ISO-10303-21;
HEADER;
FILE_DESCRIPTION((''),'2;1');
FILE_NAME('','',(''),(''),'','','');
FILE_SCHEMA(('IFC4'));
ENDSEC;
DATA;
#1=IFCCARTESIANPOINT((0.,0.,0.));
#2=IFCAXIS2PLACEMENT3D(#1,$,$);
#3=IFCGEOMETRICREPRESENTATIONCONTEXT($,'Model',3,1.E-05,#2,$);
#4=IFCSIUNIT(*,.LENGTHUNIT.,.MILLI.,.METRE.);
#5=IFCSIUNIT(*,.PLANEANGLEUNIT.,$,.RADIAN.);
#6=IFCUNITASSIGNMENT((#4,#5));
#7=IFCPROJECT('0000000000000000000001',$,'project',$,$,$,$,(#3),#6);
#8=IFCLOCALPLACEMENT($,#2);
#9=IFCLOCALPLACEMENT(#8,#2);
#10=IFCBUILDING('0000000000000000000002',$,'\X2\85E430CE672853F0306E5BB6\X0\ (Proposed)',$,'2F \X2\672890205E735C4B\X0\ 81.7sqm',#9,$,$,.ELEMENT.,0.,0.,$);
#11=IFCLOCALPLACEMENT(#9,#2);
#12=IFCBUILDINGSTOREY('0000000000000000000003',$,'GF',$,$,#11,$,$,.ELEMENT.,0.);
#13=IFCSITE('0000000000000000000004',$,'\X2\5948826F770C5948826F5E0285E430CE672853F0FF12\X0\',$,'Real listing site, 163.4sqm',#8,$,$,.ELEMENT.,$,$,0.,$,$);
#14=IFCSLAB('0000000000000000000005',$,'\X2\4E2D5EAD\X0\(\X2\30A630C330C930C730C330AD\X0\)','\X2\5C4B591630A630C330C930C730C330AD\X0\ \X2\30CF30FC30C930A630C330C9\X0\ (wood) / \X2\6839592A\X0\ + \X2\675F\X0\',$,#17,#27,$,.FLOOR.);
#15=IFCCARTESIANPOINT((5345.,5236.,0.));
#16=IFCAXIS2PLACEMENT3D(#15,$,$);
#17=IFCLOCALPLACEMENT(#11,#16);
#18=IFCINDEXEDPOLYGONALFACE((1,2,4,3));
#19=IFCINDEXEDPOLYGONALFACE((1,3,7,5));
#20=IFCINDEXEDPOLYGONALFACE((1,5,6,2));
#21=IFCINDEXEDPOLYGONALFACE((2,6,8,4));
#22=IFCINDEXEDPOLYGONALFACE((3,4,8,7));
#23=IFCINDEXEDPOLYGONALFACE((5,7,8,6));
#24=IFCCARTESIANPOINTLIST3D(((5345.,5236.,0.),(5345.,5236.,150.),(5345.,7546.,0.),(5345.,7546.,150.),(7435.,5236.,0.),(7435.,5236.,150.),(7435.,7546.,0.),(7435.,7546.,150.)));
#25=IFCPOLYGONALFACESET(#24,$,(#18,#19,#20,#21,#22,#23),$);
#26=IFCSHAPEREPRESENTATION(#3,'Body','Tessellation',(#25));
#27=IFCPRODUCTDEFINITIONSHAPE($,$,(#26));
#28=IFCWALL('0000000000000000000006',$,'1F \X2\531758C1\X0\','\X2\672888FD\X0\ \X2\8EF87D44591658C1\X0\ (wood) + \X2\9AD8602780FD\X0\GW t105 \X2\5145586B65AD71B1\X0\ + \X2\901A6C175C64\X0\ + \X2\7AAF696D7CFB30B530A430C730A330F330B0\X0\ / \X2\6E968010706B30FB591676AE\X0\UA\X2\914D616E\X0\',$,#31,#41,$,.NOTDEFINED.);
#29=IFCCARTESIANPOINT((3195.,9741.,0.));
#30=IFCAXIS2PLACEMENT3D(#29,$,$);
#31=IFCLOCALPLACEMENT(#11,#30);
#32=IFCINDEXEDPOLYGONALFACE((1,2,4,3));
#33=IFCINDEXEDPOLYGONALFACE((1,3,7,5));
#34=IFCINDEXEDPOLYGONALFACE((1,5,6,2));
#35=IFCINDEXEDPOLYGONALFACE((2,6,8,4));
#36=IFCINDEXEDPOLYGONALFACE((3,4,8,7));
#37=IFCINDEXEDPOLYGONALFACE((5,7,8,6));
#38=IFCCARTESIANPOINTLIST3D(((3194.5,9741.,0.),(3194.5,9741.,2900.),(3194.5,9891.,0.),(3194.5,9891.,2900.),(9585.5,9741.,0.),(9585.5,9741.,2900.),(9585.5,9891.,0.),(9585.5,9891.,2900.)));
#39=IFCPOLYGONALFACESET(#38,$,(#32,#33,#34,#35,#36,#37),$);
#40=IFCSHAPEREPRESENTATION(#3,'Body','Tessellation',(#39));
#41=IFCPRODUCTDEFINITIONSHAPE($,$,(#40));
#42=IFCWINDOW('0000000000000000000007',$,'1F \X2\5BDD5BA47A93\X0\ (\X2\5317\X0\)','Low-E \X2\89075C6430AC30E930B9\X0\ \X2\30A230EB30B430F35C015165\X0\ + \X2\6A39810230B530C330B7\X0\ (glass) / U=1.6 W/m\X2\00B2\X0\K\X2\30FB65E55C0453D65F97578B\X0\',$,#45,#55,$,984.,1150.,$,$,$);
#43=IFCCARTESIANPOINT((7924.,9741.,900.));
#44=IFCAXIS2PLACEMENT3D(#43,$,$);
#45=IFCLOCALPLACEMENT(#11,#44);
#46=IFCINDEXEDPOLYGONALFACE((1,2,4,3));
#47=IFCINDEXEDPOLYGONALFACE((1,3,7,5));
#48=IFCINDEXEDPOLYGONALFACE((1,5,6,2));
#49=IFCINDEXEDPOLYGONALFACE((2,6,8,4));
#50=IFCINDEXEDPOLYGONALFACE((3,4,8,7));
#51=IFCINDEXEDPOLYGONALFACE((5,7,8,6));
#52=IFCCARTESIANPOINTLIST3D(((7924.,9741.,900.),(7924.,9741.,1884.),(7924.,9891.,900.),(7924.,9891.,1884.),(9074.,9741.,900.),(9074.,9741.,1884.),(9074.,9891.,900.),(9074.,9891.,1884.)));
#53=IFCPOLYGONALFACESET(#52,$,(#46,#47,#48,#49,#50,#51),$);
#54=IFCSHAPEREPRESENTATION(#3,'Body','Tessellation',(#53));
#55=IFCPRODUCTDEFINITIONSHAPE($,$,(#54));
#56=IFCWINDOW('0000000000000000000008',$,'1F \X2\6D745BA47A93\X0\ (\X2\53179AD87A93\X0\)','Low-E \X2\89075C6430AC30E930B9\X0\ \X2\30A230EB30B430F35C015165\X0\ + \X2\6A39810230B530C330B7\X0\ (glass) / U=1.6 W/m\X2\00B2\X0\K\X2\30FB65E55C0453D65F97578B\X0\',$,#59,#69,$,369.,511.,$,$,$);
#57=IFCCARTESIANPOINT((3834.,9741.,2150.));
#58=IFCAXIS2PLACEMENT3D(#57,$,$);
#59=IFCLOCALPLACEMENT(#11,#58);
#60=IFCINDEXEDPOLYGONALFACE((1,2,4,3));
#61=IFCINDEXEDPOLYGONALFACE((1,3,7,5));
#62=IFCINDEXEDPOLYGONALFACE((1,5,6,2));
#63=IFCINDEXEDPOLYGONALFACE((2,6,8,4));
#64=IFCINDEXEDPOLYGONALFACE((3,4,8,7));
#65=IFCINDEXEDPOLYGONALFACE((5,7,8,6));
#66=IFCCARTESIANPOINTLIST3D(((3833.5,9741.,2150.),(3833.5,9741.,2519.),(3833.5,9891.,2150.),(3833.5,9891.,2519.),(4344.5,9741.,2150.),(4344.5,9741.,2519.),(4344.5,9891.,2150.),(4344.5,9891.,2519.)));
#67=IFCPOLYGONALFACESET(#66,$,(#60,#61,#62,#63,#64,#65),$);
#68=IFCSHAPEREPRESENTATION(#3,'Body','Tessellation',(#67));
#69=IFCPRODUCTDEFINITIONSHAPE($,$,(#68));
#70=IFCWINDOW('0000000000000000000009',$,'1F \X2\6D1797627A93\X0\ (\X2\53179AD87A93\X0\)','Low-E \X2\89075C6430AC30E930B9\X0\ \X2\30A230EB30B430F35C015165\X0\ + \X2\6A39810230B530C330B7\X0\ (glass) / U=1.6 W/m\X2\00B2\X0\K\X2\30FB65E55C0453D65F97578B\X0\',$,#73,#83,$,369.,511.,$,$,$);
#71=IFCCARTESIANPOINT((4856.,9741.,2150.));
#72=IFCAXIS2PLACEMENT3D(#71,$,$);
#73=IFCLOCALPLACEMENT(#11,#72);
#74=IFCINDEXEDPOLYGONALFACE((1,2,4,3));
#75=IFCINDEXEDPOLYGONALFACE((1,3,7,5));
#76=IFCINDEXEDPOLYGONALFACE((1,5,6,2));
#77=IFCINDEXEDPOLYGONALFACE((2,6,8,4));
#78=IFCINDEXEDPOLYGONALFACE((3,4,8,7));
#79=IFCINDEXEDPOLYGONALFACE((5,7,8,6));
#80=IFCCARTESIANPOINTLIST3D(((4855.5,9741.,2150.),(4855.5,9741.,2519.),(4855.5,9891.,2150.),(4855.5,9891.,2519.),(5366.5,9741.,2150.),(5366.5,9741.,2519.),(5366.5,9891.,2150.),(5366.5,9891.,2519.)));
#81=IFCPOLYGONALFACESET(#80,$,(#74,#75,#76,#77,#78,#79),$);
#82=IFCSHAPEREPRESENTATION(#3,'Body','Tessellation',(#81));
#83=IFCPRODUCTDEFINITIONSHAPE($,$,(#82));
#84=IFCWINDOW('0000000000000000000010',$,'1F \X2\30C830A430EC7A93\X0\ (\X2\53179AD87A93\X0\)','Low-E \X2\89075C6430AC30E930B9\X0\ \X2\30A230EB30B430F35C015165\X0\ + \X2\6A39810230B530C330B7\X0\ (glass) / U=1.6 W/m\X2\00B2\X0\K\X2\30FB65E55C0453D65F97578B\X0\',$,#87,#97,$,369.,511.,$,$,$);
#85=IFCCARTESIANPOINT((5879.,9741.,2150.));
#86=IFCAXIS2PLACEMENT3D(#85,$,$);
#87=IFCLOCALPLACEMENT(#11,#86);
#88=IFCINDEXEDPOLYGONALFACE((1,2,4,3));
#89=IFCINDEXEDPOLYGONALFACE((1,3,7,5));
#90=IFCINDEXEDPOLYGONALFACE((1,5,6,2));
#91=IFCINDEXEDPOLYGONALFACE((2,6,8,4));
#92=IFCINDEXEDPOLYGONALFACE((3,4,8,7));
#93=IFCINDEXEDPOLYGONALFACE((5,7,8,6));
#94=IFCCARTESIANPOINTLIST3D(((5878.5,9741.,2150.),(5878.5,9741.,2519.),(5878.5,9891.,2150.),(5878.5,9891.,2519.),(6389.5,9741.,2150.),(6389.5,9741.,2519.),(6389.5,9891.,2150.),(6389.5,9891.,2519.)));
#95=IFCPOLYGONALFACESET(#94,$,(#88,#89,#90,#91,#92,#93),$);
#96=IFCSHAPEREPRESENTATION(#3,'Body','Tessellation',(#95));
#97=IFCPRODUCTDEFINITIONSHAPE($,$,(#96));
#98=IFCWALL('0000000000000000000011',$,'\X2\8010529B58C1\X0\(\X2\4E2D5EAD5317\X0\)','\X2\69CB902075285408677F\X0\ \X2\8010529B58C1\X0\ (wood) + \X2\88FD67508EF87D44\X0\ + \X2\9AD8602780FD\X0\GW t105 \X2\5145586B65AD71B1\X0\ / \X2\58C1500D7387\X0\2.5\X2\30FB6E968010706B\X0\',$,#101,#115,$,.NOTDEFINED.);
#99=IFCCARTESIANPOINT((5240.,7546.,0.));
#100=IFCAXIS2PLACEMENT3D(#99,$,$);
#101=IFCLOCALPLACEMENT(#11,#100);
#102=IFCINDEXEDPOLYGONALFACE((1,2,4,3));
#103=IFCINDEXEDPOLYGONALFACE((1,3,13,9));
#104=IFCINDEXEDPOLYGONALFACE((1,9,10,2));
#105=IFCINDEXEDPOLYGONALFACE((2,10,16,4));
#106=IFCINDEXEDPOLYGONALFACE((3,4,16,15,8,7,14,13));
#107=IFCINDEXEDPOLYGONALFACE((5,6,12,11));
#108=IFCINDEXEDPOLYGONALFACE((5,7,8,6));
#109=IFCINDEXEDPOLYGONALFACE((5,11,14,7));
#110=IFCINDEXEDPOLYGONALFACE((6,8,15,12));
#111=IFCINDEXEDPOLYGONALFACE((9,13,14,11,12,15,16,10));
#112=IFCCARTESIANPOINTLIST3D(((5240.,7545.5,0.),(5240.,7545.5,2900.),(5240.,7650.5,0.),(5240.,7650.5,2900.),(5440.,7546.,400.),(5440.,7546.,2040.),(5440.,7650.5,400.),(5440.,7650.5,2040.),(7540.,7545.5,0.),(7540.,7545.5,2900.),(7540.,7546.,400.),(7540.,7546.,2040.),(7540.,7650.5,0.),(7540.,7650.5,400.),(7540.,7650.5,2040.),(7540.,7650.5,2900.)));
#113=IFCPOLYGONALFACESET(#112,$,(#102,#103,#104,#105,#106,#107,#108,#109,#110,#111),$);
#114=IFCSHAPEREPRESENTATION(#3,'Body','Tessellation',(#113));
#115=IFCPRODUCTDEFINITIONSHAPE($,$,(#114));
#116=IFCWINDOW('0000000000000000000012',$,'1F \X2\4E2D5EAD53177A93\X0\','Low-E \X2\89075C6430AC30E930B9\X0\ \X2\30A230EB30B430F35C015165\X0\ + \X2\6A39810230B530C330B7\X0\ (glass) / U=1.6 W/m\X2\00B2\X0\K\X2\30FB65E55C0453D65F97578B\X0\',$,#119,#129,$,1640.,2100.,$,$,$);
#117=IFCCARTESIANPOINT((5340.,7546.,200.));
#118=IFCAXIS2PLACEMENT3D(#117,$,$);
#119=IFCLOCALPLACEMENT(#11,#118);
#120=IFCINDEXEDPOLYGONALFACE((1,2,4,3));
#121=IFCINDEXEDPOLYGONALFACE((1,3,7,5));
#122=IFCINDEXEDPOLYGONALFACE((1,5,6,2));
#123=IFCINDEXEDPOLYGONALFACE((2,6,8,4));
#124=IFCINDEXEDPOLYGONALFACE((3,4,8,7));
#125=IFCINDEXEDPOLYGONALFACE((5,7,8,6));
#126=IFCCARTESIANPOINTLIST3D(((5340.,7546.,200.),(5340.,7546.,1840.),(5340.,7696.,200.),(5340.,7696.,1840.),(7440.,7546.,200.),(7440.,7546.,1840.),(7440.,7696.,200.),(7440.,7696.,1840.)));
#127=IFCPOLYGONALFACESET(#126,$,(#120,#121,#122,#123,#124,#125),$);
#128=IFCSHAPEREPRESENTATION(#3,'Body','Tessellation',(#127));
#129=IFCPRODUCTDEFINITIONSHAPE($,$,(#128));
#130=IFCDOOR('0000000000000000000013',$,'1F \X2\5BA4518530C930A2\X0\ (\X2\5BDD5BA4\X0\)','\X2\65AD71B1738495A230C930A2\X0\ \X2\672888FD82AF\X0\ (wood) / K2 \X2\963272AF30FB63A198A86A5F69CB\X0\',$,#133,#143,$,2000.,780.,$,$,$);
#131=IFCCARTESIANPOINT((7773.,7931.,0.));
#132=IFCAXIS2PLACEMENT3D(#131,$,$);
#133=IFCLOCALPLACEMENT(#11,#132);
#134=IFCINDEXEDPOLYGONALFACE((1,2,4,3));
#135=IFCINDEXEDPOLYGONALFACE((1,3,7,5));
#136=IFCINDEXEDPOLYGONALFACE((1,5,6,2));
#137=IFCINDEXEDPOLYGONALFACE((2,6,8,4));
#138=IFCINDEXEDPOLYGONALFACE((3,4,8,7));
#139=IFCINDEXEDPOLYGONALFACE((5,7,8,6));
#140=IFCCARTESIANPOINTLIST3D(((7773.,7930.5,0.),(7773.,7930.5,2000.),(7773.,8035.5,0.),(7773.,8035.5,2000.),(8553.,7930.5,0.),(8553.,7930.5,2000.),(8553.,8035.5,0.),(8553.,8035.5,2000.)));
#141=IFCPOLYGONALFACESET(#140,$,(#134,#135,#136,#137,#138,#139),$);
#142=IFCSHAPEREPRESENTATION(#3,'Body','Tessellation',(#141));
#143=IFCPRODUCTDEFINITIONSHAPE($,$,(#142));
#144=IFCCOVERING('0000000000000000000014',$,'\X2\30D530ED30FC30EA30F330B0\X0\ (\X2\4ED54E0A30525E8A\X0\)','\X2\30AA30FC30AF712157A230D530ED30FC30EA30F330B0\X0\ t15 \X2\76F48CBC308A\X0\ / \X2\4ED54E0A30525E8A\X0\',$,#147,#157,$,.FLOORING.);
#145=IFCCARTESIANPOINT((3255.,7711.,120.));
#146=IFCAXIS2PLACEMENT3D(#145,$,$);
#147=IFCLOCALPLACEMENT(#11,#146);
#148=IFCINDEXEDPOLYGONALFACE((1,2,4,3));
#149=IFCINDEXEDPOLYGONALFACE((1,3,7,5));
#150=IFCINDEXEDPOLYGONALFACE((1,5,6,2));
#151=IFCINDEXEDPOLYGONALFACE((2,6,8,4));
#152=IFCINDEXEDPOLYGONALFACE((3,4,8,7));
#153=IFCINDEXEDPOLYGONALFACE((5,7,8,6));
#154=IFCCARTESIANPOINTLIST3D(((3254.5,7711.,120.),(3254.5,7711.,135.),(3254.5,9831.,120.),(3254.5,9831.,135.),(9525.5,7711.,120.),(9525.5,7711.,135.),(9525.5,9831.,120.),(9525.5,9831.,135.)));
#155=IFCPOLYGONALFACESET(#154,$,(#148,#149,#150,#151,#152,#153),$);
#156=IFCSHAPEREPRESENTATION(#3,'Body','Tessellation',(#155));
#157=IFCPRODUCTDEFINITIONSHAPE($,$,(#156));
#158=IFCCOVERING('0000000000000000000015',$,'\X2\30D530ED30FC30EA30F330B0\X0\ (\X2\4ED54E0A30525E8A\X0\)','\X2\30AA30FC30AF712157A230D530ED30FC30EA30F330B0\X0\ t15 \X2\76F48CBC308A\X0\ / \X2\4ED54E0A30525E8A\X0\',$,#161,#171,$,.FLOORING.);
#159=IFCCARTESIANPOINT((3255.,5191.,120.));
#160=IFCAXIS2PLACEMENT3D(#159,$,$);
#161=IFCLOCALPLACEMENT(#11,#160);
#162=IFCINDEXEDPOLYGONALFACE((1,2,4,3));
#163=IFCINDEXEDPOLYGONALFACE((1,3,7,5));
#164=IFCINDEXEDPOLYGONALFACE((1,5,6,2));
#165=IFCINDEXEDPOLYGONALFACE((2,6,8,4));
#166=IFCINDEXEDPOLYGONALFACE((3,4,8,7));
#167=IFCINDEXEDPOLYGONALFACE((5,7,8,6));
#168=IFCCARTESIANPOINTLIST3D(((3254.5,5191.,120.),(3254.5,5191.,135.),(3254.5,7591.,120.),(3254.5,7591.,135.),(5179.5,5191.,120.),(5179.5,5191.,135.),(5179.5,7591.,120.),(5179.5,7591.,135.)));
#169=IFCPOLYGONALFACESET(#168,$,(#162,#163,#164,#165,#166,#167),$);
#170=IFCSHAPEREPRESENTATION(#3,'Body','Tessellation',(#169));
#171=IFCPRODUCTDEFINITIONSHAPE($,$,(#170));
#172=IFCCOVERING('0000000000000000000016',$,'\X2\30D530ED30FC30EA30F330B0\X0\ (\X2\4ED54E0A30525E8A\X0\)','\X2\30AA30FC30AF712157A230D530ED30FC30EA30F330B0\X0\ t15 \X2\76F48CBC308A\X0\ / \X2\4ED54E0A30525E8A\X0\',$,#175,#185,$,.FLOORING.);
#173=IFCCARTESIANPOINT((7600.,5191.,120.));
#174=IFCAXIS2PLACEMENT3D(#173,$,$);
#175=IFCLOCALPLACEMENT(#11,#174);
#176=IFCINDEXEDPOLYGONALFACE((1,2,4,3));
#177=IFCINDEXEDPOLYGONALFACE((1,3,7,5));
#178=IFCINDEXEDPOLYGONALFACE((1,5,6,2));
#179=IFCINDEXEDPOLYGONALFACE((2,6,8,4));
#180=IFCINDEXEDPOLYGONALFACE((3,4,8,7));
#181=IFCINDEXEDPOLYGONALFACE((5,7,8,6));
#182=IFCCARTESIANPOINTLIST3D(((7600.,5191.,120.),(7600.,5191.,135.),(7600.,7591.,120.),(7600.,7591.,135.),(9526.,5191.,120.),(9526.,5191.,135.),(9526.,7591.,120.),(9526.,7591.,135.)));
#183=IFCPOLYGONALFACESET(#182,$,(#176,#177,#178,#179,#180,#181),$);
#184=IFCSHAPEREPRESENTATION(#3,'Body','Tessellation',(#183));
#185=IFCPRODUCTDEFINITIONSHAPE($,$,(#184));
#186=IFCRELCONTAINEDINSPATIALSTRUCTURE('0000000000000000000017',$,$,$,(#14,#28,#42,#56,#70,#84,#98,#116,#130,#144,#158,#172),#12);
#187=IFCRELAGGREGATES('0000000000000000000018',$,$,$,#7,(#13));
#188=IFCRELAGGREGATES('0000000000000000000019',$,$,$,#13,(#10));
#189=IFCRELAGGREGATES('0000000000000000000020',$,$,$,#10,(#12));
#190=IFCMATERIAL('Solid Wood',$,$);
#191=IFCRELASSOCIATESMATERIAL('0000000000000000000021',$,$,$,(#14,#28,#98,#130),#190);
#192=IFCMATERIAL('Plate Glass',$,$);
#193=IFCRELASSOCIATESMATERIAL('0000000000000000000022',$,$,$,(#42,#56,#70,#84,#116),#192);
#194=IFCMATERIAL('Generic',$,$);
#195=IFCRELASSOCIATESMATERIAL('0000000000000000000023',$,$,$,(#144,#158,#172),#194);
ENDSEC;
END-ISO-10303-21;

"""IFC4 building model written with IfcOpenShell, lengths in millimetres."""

from ifc_helpers import new_model, si_unit, frame, frame_2d, origin, place, context, project, spatial, rectangle, extrude, material, element, fill, save


model = new_model("IFC4")

# Units and contexts
model_context = context("Model", 3, precision=1e-05, world=origin())
ifc_project = project(units=[si_unit("LENGTHUNIT", "METRE", prefix="MILLI"), si_unit("PLANEANGLEUNIT", "RADIAN")], contexts=[model_context])

# Site, building, storey
site_placement = place(None, origin())
site = spatial("IfcSite", under=ifc_project, at=site_placement, Name="奈良県奈良市藤ノ木台２", ObjectType="Real listing site, 163.4sqm", CompositionType="ELEMENT", RefElevation=0.0)
building_placement = place(site_placement, origin())
building = spatial("IfcBuilding", under=site, at=building_placement, Name="藤ノ木台の家 (Proposed)", ObjectType="2F 木造平屋 81.7sqm", CompositionType="ELEMENT", ElevationOfRefHeight=0.0, ElevationOfTerrain=0.0)
storey_placement = place(building_placement, origin())
storey = spatial("IfcBuildingStorey", under=building, at=storey_placement, Name="GF", CompositionType="ELEMENT", Elevation=0.0)

# Slab
ifc_material_1 = material(Name="Solid Wood")
slab_1_placement = place(storey_placement, frame((5345.0, 5236.0, 0.0)))
element("IfcSlab", 1, at=slab_1_placement, inside=storey, material=ifc_material_1, Name="中庭(ウッドデッキ)", Description="屋外ウッドデッキ ハードウッド (wood) / 根太 + 束", PredefinedType="FLOOR", context=model_context, shape_type="SweptSolid", body=[
    extrude(rectangle(XDim=2090.0, YDim=2310.0, at=frame_2d((1045.0, 1155.0))), frame((5345.0, 5236.0, 0.0)), (0.0, 0.0, 1.0), 150.0),
])

# Wall, openings, windows
wall_1_placement = place(storey_placement, frame((3195.0, 9741.0, 0.0)))
wall_1 = element("IfcWall", 2, at=wall_1_placement, inside=storey, material=ifc_material_1, Name="1F 北壁", Description="木製 軸組外壁 (wood) + 高性能GW t105 充填断熱 + 通気層 + 窯業系サイディング / 準耐火・外皮UA配慮", PredefinedType="NOTDEFINED", context=model_context, shape_type="SweptSolid", body=[
    extrude(rectangle(XDim=6391.0, YDim=150.0, at=frame_2d((3195.0, 75.0))), frame((3195.0, 9741.0, 0.0)), (0.0, 0.0, 1.0), 2900.0),
])
opening_1_placement = place(storey_placement, frame((7924.0, 9741.0, 900.0)))
opening_1 = element("IfcOpeningElement", 3, at=opening_1_placement, cuts=wall_1, PredefinedType="NOTDEFINED", context=model_context, shape_type="SweptSolid", body=[
    extrude(rectangle(XDim=1150.0, YDim=150.0, at=frame_2d((575.0, 75.0))), frame((7924.0, 9741.0, 900.0)), (0.0, 0.0, 1.0), 984.0),
])
opening_2_placement = place(storey_placement, frame((3834.0, 9741.0, 2150.0)))
opening_2 = element("IfcOpeningElement", 4, at=opening_2_placement, cuts=wall_1, PredefinedType="NOTDEFINED", context=model_context, shape_type="SweptSolid", body=[
    extrude(rectangle(XDim=511.0, YDim=150.0, at=frame_2d((255.0, 75.0))), frame((3834.0, 9741.0, 2150.0)), (0.0, 0.0, 1.0), 369.0),
])
opening_3_placement = place(storey_placement, frame((4856.0, 9741.0, 2150.0)))
opening_3 = element("IfcOpeningElement", 5, at=opening_3_placement, cuts=wall_1, PredefinedType="NOTDEFINED", context=model_context, shape_type="SweptSolid", body=[
    extrude(rectangle(XDim=511.0, YDim=150.0, at=frame_2d((255.0, 75.0))), frame((4856.0, 9741.0, 2150.0)), (0.0, 0.0, 1.0), 369.0),
])
opening_4_placement = place(storey_placement, frame((5879.0, 9741.0, 2150.0)))
opening_4 = element("IfcOpeningElement", 6, at=opening_4_placement, cuts=wall_1, PredefinedType="NOTDEFINED", context=model_context, shape_type="SweptSolid", body=[
    extrude(rectangle(XDim=511.0, YDim=150.0, at=frame_2d((255.0, 75.0))), frame((5879.0, 9741.0, 2150.0)), (0.0, 0.0, 1.0), 369.0),
])
ifc_material_2 = material(Name="Plate Glass")
window_1_placement = place(storey_placement, frame((7924.0, 9741.0, 900.0)))
window_1 = element("IfcWindow", 7, at=window_1_placement, inside=storey, material=ifc_material_2, Name="1F 寝室窓 (北)", Description="Low-E 複層ガラス アルゴン封入 + 樹脂サッシ (glass) / U=1.6 W/m²K・日射取得型", OverallHeight=984.0, OverallWidth=1150.0, context=model_context, shape_type="SweptSolid", body=[
    extrude(rectangle(XDim=1150.0, YDim=150.0, at=frame_2d((575.0, 75.0))), frame((7924.0, 9741.0, 900.0)), (0.0, 0.0, 1.0), 984.0),
])
fill(opening_1, window_1)
window_2_placement = place(storey_placement, frame((3834.0, 9741.0, 2150.0)))
window_2 = element("IfcWindow", 8, at=window_2_placement, inside=storey, material=ifc_material_2, Name="1F 浴室窓 (北高窓)", Description="Low-E 複層ガラス アルゴン封入 + 樹脂サッシ (glass) / U=1.6 W/m²K・日射取得型", OverallHeight=369.0, OverallWidth=511.0, context=model_context, shape_type="SweptSolid", body=[
    extrude(rectangle(XDim=511.0, YDim=150.0, at=frame_2d((255.0, 75.0))), frame((3834.0, 9741.0, 2150.0)), (0.0, 0.0, 1.0), 369.0),
])
fill(opening_2, window_2)
window_3_placement = place(storey_placement, frame((4856.0, 9741.0, 2150.0)))
window_3 = element("IfcWindow", 9, at=window_3_placement, inside=storey, material=ifc_material_2, Name="1F 洗面窓 (北高窓)", Description="Low-E 複層ガラス アルゴン封入 + 樹脂サッシ (glass) / U=1.6 W/m²K・日射取得型", OverallHeight=369.0, OverallWidth=511.0, context=model_context, shape_type="SweptSolid", body=[
    extrude(rectangle(XDim=511.0, YDim=150.0, at=frame_2d((255.0, 75.0))), frame((4856.0, 9741.0, 2150.0)), (0.0, 0.0, 1.0), 369.0),
])
fill(opening_3, window_3)
window_4_placement = place(storey_placement, frame((5879.0, 9741.0, 2150.0)))
window_4 = element("IfcWindow", 10, at=window_4_placement, inside=storey, material=ifc_material_2, Name="1F トイレ窓 (北高窓)", Description="Low-E 複層ガラス アルゴン封入 + 樹脂サッシ (glass) / U=1.6 W/m²K・日射取得型", OverallHeight=369.0, OverallWidth=511.0, context=model_context, shape_type="SweptSolid", body=[
    extrude(rectangle(XDim=511.0, YDim=150.0, at=frame_2d((255.0, 75.0))), frame((5879.0, 9741.0, 2150.0)), (0.0, 0.0, 1.0), 369.0),
])
fill(opening_4, window_4)

# Wall, opening, window
wall_2_placement = place(storey_placement, frame((5240.0, 7546.0, 0.0)))
wall_2 = element("IfcWall", 11, at=wall_2_placement, inside=storey, material=ifc_material_1, Name="耐力壁(中庭北)", Description="構造用合板 耐力壁 (wood) + 製材軸組 + 高性能GW t105 充填断熱 / 壁倍率2.5・準耐火", PredefinedType="NOTDEFINED", context=model_context, shape_type="SweptSolid", body=[
    extrude(rectangle(XDim=2300.0, YDim=105.0, at=frame_2d((1150.0, 52.0))), frame((5240.0, 7546.0, 0.0)), (0.0, 0.0, 1.0), 2900.0),
])
opening_5_placement = place(storey_placement, frame((5340.0, 7546.0, 200.0)))
opening_5 = element("IfcOpeningElement", 12, at=opening_5_placement, cuts=wall_2, PredefinedType="NOTDEFINED", context=model_context, shape_type="SweptSolid", body=[
    extrude(rectangle(XDim=2100.0, YDim=150.0, at=frame_2d((1050.0, 75.0))), frame((5340.0, 7546.0, 200.0)), (0.0, 0.0, 1.0), 1640.0),
])
window_5_placement = place(storey_placement, frame((5340.0, 7546.0, 200.0)))
window_5 = element("IfcWindow", 13, at=window_5_placement, inside=storey, material=ifc_material_2, Name="1F 中庭北窓", Description="Low-E 複層ガラス アルゴン封入 + 樹脂サッシ (glass) / U=1.6 W/m²K・日射取得型", OverallHeight=1640.0, OverallWidth=2100.0, context=model_context, shape_type="SweptSolid", body=[
    extrude(rectangle(XDim=2100.0, YDim=150.0, at=frame_2d((1050.0, 75.0))), frame((5340.0, 7546.0, 200.0)), (0.0, 0.0, 1.0), 1640.0),
])
fill(opening_5, window_5)

# Door
door_1_placement = place(storey_placement, frame((7773.0, 7931.0, 0.0)))
element("IfcDoor", 14, at=door_1_placement, inside=storey, material=ifc_material_1, Name="1F 室内ドア (寝室)", Description="断熱玄関ドア 木製芯 (wood) / K2 防犯・採風機構", OverallHeight=2000.0, OverallWidth=780.0, context=model_context, shape_type="SweptSolid", body=[
    extrude(rectangle(XDim=780.0, YDim=105.0, at=frame_2d((390.0, 52.0))), frame((7773.0, 7931.0, 0.0)), (0.0, 0.0, 1.0), 2000.0),
])

# Coverings
ifc_material_3 = material(Name="Generic")
covering_1_placement = place(storey_placement, frame((3255.0, 7711.0, 120.0)))
element("IfcCovering", 15, at=covering_1_placement, inside=storey, material=ifc_material_3, Name="フローリング (仕上げ床)", Description="オーク無垢フローリング t15 直貼り / 仕上げ床", PredefinedType="FLOORING", context=model_context, shape_type="SweptSolid", body=[
    extrude(rectangle(XDim=6271.0, YDim=2120.0, at=frame_2d((3135.0, 1060.0))), frame((3255.0, 7711.0, 120.0)), (0.0, 0.0, 1.0), 15.0),
])
covering_2_placement = place(storey_placement, frame((3255.0, 5191.0, 120.0)))
element("IfcCovering", 16, at=covering_2_placement, inside=storey, material=ifc_material_3, Name="フローリング (仕上げ床)", Description="オーク無垢フローリング t15 直貼り / 仕上げ床", PredefinedType="FLOORING", context=model_context, shape_type="SweptSolid", body=[
    extrude(rectangle(XDim=1925.0, YDim=2400.0, at=frame_2d((962.0, 1200.0))), frame((3255.0, 5191.0, 120.0)), (0.0, 0.0, 1.0), 15.0),
])
covering_3_placement = place(storey_placement, frame((7600.0, 5191.0, 120.0)))
element("IfcCovering", 17, at=covering_3_placement, inside=storey, material=ifc_material_3, Name="フローリング (仕上げ床)", Description="オーク無垢フローリング t15 直貼り / 仕上げ床", PredefinedType="FLOORING", context=model_context, shape_type="SweptSolid", body=[
    extrude(rectangle(XDim=1926.0, YDim=2400.0, at=frame_2d((963.0, 1200.0))), frame((7600.0, 5191.0, 120.0)), (0.0, 0.0, 1.0), 15.0),
])

save(model, "model.ifc")
